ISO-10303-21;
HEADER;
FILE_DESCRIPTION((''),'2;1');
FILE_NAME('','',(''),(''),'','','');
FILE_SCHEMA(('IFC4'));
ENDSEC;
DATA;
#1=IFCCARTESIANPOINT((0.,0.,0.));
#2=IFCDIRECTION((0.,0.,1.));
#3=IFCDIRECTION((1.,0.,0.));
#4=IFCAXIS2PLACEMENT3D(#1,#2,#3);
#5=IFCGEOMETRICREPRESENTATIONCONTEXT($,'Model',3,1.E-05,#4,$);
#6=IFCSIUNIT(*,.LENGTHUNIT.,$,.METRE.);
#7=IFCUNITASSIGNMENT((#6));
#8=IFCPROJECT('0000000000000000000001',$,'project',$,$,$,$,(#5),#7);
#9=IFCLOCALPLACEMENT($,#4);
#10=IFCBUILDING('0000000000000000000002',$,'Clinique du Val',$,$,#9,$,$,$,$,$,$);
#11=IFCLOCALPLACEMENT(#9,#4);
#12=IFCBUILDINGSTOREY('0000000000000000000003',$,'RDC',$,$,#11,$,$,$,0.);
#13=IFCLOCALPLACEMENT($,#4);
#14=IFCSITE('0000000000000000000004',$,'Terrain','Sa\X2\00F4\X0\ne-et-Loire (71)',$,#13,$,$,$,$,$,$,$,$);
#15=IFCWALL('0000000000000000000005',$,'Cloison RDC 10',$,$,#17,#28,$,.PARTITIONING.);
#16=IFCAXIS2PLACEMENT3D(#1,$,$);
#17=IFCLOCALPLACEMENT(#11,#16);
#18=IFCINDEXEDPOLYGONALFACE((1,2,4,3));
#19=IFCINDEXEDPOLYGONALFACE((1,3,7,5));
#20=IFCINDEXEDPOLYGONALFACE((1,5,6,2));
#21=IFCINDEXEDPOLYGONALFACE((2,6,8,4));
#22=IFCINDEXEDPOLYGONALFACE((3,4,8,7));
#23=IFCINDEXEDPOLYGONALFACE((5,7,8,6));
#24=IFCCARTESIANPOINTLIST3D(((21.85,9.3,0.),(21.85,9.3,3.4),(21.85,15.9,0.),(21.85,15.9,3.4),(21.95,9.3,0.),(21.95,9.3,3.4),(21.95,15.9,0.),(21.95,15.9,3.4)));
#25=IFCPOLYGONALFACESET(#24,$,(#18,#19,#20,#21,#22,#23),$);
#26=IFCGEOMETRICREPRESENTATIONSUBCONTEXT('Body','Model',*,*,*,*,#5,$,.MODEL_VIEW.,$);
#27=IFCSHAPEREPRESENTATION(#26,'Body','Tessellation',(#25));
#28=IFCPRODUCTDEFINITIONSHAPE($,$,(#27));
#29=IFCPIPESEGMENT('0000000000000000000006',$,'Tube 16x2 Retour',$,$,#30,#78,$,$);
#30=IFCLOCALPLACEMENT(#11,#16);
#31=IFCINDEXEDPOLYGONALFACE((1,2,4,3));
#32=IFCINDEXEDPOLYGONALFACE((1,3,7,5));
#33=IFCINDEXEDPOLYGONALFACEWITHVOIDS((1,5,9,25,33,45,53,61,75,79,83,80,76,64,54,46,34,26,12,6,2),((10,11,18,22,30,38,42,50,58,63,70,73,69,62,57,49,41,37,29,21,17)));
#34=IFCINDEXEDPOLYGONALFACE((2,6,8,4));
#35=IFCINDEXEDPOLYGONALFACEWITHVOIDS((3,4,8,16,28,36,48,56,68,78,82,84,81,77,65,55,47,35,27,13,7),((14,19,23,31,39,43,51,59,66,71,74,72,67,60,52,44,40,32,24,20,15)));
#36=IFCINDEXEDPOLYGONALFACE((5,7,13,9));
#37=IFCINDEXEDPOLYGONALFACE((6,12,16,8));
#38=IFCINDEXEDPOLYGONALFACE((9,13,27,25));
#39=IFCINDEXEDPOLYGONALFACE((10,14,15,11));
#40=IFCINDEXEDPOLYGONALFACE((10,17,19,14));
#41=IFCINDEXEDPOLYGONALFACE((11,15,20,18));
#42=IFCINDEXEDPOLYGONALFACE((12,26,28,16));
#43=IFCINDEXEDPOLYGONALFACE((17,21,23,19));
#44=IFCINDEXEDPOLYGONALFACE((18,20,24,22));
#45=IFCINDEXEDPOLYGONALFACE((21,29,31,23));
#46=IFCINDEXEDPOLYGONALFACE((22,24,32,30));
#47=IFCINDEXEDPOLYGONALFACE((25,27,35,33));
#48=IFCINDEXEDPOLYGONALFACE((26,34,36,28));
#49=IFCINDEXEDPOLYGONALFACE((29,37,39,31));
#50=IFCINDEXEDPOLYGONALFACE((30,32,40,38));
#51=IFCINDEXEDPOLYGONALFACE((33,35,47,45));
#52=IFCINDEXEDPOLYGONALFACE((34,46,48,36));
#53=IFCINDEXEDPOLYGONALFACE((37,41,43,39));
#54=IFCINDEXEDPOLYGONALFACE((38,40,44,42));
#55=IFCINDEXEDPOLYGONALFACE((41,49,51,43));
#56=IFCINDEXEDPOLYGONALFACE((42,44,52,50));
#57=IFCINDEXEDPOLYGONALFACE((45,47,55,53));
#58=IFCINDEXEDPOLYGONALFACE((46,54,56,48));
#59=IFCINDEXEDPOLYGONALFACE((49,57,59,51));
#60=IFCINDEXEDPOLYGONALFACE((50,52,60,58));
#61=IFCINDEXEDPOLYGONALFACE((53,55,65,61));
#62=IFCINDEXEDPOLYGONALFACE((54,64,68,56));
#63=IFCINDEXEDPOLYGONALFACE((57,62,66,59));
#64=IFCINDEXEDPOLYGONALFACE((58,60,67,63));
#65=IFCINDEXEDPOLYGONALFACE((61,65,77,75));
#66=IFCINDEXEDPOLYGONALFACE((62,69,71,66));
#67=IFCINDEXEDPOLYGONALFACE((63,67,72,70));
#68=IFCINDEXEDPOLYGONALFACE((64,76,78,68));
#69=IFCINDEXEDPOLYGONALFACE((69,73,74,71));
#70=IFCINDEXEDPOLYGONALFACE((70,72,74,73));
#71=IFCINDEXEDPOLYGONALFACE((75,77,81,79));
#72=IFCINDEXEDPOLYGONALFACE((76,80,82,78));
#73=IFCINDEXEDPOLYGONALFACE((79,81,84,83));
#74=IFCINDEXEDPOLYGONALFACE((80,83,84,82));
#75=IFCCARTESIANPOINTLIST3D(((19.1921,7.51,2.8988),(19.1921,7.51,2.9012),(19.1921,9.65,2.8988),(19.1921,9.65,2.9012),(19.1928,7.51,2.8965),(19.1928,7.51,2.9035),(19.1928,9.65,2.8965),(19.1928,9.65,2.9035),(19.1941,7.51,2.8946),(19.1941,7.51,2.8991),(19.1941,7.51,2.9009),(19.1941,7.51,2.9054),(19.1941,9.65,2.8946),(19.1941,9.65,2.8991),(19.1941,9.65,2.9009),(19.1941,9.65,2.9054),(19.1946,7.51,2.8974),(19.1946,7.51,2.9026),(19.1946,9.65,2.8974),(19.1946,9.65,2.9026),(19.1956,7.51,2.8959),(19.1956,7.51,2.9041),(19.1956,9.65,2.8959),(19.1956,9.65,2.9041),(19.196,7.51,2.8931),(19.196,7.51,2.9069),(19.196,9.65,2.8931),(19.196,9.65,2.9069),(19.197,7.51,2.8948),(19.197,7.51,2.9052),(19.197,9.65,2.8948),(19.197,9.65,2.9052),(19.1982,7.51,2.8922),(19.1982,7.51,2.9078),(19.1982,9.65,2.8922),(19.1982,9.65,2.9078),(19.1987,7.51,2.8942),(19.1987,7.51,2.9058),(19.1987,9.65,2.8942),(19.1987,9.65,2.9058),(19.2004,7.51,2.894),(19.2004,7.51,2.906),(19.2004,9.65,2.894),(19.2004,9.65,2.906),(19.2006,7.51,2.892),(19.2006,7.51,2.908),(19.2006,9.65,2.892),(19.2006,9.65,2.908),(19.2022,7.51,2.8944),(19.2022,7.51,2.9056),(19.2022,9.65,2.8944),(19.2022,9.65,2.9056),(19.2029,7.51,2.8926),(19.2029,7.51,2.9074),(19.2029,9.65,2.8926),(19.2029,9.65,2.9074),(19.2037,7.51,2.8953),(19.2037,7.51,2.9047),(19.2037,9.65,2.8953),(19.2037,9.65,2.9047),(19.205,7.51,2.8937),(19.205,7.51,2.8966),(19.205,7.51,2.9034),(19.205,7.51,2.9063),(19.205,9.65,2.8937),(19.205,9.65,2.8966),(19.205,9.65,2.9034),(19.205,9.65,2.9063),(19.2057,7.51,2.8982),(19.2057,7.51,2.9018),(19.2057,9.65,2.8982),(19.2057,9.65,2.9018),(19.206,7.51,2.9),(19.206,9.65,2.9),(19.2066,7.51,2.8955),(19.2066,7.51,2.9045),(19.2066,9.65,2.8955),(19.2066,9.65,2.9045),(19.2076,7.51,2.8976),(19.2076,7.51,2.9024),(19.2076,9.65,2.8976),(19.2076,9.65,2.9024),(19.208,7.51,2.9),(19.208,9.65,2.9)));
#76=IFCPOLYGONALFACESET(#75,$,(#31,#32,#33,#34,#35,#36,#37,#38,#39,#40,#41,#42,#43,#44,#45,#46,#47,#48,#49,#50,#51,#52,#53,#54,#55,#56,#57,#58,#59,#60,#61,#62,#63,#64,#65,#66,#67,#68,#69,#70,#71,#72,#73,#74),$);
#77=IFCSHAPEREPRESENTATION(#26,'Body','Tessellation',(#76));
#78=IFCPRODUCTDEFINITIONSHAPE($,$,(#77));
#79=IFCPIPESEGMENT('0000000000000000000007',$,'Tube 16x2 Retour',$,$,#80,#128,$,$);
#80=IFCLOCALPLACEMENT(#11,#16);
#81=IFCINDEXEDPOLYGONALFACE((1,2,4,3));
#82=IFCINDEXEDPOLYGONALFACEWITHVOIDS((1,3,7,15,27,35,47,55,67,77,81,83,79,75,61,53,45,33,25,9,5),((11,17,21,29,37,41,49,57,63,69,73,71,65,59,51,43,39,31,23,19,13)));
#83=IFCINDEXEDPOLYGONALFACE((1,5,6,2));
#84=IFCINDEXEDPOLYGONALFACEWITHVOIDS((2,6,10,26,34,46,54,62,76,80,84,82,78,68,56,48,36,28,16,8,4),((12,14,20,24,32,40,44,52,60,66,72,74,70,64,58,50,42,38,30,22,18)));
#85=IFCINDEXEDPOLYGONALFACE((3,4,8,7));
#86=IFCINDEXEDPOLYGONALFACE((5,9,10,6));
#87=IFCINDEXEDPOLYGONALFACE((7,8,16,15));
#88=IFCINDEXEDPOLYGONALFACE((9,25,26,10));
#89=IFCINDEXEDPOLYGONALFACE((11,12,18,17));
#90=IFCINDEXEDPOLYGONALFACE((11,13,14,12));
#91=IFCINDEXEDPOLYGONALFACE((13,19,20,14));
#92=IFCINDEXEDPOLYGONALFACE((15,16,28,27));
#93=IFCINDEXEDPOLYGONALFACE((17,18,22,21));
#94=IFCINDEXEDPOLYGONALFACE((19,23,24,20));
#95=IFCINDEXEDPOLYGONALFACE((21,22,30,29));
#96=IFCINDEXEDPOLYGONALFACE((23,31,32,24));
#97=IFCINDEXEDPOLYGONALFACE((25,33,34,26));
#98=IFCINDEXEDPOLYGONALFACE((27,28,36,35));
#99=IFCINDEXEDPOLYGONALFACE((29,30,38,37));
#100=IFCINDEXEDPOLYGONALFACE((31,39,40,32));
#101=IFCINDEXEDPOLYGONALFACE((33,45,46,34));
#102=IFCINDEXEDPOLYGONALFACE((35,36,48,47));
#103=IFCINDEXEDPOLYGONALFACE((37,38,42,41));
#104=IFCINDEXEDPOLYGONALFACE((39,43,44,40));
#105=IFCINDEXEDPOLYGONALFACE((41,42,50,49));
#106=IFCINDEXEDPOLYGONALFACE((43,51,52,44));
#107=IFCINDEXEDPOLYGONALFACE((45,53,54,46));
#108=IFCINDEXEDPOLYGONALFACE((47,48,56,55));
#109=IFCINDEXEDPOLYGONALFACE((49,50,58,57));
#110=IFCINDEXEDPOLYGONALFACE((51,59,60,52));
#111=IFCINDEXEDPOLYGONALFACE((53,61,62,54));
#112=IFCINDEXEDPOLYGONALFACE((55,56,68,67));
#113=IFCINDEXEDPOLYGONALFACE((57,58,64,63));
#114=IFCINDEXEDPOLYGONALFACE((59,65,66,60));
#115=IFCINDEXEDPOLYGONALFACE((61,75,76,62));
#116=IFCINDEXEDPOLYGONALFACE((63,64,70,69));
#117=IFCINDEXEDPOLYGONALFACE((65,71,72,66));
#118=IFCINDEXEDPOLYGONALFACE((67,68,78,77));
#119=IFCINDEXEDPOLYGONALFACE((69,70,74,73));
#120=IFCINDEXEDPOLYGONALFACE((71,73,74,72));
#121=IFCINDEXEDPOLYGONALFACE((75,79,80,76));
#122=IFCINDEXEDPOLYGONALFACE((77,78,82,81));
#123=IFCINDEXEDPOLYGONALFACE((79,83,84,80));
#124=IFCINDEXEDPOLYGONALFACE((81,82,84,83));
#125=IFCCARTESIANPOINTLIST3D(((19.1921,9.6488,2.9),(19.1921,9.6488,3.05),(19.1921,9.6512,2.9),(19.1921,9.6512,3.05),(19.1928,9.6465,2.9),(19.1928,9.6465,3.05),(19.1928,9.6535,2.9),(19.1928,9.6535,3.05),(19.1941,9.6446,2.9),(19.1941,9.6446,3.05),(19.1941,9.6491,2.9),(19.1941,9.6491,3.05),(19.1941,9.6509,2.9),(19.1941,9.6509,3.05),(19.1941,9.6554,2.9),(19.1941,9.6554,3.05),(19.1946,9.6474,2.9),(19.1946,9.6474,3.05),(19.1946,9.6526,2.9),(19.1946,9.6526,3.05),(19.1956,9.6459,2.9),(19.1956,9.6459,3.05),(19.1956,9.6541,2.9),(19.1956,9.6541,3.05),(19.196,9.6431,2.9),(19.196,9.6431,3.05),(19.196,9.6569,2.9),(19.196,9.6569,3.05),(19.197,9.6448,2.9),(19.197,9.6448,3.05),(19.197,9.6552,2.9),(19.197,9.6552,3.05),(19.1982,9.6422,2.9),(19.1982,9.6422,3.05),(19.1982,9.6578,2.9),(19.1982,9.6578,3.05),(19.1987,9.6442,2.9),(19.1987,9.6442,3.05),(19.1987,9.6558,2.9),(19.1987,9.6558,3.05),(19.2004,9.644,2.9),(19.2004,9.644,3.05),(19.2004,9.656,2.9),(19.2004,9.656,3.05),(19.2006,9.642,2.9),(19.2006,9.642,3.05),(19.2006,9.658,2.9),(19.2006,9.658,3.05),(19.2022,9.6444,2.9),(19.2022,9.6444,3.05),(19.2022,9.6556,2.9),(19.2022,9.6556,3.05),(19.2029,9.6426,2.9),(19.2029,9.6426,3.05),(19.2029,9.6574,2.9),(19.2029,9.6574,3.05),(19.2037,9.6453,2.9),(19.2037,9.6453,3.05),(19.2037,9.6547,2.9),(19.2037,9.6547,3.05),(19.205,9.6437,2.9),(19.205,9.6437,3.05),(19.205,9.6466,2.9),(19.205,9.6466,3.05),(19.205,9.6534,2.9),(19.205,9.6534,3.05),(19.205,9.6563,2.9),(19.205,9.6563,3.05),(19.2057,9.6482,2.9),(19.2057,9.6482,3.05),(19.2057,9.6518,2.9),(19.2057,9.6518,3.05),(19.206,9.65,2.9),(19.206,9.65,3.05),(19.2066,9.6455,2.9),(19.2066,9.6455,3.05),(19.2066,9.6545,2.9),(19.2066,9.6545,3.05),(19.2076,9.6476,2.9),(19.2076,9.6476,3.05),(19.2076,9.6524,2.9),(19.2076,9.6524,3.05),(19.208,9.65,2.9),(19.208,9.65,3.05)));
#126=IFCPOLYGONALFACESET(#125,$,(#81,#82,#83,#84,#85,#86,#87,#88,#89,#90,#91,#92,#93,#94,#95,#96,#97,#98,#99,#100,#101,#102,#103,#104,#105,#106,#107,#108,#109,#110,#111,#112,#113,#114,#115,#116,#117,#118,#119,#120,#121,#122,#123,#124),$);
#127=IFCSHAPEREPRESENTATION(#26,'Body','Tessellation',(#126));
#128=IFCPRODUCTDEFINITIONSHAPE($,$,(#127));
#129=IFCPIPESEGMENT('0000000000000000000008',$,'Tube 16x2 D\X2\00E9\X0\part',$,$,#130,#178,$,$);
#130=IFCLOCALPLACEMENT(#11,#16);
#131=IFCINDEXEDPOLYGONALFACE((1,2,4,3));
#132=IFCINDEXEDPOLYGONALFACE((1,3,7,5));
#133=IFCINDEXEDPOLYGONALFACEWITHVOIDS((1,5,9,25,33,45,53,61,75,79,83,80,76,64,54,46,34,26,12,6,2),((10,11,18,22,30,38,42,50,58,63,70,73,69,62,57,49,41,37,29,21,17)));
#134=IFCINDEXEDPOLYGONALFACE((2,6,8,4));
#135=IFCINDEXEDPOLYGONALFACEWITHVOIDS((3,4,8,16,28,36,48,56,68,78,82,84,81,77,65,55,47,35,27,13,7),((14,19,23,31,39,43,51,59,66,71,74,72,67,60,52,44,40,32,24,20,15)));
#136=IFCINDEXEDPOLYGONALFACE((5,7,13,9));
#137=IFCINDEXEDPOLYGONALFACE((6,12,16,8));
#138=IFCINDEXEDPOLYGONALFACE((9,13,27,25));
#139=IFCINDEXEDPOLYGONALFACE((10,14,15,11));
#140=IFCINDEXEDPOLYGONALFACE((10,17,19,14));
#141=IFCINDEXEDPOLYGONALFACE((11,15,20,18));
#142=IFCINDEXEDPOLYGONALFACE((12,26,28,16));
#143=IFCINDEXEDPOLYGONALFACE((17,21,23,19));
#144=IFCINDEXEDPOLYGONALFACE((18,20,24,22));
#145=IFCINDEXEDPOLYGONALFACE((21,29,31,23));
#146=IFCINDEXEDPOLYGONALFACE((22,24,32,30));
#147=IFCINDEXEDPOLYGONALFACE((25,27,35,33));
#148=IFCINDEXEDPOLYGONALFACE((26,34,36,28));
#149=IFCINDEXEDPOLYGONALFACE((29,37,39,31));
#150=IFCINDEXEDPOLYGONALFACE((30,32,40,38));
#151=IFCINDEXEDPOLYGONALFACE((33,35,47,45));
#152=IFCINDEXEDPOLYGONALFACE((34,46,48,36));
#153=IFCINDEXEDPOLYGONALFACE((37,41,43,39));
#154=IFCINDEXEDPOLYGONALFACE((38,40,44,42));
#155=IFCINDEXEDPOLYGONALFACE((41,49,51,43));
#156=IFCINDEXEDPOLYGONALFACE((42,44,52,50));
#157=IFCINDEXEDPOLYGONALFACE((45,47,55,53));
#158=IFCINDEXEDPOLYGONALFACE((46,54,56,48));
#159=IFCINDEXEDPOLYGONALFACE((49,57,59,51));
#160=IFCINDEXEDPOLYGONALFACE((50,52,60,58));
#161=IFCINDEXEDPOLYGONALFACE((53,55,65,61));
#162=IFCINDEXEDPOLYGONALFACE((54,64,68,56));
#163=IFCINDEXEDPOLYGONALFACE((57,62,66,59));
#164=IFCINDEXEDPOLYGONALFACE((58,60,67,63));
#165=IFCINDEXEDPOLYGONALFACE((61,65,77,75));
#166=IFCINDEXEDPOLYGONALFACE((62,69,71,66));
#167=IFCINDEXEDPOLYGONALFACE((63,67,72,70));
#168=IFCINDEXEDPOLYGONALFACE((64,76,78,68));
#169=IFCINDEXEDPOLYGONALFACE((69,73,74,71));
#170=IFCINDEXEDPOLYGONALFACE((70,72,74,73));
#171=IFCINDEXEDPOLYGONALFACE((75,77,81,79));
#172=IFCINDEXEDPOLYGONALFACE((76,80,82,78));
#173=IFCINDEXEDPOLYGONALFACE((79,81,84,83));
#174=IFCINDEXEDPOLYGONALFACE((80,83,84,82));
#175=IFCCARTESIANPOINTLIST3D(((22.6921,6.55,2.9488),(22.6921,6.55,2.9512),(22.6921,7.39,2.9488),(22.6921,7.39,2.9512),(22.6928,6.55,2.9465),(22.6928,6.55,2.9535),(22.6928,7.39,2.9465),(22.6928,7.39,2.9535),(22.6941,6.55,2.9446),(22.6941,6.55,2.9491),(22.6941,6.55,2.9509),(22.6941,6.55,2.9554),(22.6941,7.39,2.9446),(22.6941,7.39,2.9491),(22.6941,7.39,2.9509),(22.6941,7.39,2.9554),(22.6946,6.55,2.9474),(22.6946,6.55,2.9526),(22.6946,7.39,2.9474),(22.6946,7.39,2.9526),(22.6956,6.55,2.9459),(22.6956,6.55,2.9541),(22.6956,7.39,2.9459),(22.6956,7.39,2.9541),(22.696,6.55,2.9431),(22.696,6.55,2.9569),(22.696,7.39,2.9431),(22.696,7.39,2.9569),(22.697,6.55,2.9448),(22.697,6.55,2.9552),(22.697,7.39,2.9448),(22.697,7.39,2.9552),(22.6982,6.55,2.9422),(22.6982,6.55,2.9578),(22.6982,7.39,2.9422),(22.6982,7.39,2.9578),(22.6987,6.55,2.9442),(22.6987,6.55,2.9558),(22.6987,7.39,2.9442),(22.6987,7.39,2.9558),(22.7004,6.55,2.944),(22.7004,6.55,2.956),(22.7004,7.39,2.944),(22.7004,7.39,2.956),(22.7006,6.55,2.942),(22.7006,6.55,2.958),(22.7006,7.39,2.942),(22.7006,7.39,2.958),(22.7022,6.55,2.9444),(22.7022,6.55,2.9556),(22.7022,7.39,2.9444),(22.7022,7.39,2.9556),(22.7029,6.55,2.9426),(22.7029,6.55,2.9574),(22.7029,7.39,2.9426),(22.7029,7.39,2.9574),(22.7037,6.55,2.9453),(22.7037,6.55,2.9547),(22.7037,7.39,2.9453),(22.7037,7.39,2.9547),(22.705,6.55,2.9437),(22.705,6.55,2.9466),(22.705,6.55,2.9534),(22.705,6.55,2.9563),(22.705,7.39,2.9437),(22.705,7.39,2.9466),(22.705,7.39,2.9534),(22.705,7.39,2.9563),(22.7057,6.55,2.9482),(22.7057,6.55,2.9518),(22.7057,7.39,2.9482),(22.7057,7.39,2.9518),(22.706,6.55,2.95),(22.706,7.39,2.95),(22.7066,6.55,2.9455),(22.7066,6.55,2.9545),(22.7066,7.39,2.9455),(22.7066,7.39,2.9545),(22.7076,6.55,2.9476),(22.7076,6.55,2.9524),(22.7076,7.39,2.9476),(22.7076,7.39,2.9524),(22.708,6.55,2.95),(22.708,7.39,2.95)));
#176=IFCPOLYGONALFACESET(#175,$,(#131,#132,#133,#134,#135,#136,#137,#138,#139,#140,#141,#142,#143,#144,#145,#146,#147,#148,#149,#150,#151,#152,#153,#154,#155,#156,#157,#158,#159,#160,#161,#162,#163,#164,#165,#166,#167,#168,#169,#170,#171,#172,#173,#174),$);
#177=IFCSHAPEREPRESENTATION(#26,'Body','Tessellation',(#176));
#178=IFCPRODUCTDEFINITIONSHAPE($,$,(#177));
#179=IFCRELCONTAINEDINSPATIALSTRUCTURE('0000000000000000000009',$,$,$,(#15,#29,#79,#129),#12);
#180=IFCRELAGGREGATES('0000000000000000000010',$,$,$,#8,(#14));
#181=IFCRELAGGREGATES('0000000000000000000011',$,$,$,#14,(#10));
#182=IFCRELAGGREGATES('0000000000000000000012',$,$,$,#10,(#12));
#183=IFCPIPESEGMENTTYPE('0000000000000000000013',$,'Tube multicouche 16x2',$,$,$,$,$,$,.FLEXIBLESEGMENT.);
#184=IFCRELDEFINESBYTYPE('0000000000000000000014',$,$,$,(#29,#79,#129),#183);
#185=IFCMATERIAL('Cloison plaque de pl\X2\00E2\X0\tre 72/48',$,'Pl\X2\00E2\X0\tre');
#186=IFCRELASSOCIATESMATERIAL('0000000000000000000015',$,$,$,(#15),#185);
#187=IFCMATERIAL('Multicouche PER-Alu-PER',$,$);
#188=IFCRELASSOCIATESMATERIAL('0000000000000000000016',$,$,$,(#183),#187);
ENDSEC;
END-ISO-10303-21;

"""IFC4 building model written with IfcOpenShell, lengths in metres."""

from ifc_helpers import new_model, si_unit, frame, frame_2d, origin_with_axes, place, context, subcontext, project, spatial, rectangle, hollow_circle, extrude, material, type_object, element, save


model = new_model("IFC4")

# Units and contexts
model_context = context("Model", 3, precision=1e-05, world=origin_with_axes())
body_context = subcontext(model_context, "Body", "Model", "MODEL_VIEW")
ifc_project = project(units=[si_unit("LENGTHUNIT", "METRE")], contexts=[model_context])

# Site, building, storey
site_placement = place(None, origin_with_axes())
site = spatial("IfcSite", under=ifc_project, at=site_placement, Name="Terrain", Description="Saône-et-Loire (71)")
building_placement = place(None, origin_with_axes())
building = spatial("IfcBuilding", under=site, at=building_placement, Name="Clinique du Val")
storey_placement = place(building_placement, origin_with_axes())
storey = spatial("IfcBuildingStorey", under=building, at=storey_placement, Name="RDC", Elevation=0.0)

# Wall
ifc_material_1 = material(Name="Cloison plaque de plâtre 72/48", Category="Plâtre")
wall_placement = place(storey_placement, frame((21.85, 9.3, 0.0), z_axis=(0.0, 0.0, 1.0), x_axis=(1.0, 0.0, 0.0)))
element("IfcWall", 1, at=wall_placement, inside=storey, material=ifc_material_1, Name="Cloison RDC 10", PredefinedType="PARTITIONING", context=body_context, shape_type="SweptSolid", body=[
    extrude(rectangle(XDim=0.1, YDim=6.6, at=frame_2d((0.05, 3.3))), origin_with_axes(), (0.0, 0.0, 1.0), 3.4),
])

# Pipe segments
ifc_material_2 = material(Name="Multicouche PER-Alu-PER")
pipe_segment_type = type_object("IfcPipeSegmentType", Name="Tube multicouche 16x2", PredefinedType="FLEXIBLESEGMENT", material=ifc_material_2)
pipe_segment_1_placement = place(storey_placement, frame((19.2, 7.51, 2.9), z_axis=(0.0, 1.0, 0.0), x_axis=(1.0, 0.0, 0.0)))
element("IfcPipeSegment", 2, at=pipe_segment_1_placement, inside=storey, type_object=pipe_segment_type, Name="Tube 16x2 Retour", context=body_context, shape_type="SweptSolid", body=[
    extrude(hollow_circle(Radius=0.008, WallThickness=0.002), origin_with_axes(), (0.0, 0.0, 1.0), 2.14),
])
pipe_segment_2_placement = place(storey_placement, frame((19.2, 9.65, 2.9), z_axis=(0.0, 0.0, 1.0), x_axis=(1.0, 0.0, 0.0)))
element("IfcPipeSegment", 3, at=pipe_segment_2_placement, inside=storey, type_object=pipe_segment_type, Name="Tube 16x2 Retour", context=body_context, shape_type="SweptSolid", body=[
    extrude(hollow_circle(Radius=0.008, WallThickness=0.002), origin_with_axes(), (0.0, 0.0, 1.0), 0.15),
])
pipe_segment_3_placement = place(storey_placement, frame((22.7, 7.39, 2.95), z_axis=(0.0, -1.0, 0.0), x_axis=(1.0, 0.0, 0.0)))
element("IfcPipeSegment", 4, at=pipe_segment_3_placement, inside=storey, type_object=pipe_segment_type, Name="Tube 16x2 Départ", context=body_context, shape_type="SweptSolid", body=[
    extrude(hollow_circle(Radius=0.008, WallThickness=0.002), origin_with_axes(), (0.0, 0.0, 1.0), 0.84),
])

save(model, "model.ifc")
